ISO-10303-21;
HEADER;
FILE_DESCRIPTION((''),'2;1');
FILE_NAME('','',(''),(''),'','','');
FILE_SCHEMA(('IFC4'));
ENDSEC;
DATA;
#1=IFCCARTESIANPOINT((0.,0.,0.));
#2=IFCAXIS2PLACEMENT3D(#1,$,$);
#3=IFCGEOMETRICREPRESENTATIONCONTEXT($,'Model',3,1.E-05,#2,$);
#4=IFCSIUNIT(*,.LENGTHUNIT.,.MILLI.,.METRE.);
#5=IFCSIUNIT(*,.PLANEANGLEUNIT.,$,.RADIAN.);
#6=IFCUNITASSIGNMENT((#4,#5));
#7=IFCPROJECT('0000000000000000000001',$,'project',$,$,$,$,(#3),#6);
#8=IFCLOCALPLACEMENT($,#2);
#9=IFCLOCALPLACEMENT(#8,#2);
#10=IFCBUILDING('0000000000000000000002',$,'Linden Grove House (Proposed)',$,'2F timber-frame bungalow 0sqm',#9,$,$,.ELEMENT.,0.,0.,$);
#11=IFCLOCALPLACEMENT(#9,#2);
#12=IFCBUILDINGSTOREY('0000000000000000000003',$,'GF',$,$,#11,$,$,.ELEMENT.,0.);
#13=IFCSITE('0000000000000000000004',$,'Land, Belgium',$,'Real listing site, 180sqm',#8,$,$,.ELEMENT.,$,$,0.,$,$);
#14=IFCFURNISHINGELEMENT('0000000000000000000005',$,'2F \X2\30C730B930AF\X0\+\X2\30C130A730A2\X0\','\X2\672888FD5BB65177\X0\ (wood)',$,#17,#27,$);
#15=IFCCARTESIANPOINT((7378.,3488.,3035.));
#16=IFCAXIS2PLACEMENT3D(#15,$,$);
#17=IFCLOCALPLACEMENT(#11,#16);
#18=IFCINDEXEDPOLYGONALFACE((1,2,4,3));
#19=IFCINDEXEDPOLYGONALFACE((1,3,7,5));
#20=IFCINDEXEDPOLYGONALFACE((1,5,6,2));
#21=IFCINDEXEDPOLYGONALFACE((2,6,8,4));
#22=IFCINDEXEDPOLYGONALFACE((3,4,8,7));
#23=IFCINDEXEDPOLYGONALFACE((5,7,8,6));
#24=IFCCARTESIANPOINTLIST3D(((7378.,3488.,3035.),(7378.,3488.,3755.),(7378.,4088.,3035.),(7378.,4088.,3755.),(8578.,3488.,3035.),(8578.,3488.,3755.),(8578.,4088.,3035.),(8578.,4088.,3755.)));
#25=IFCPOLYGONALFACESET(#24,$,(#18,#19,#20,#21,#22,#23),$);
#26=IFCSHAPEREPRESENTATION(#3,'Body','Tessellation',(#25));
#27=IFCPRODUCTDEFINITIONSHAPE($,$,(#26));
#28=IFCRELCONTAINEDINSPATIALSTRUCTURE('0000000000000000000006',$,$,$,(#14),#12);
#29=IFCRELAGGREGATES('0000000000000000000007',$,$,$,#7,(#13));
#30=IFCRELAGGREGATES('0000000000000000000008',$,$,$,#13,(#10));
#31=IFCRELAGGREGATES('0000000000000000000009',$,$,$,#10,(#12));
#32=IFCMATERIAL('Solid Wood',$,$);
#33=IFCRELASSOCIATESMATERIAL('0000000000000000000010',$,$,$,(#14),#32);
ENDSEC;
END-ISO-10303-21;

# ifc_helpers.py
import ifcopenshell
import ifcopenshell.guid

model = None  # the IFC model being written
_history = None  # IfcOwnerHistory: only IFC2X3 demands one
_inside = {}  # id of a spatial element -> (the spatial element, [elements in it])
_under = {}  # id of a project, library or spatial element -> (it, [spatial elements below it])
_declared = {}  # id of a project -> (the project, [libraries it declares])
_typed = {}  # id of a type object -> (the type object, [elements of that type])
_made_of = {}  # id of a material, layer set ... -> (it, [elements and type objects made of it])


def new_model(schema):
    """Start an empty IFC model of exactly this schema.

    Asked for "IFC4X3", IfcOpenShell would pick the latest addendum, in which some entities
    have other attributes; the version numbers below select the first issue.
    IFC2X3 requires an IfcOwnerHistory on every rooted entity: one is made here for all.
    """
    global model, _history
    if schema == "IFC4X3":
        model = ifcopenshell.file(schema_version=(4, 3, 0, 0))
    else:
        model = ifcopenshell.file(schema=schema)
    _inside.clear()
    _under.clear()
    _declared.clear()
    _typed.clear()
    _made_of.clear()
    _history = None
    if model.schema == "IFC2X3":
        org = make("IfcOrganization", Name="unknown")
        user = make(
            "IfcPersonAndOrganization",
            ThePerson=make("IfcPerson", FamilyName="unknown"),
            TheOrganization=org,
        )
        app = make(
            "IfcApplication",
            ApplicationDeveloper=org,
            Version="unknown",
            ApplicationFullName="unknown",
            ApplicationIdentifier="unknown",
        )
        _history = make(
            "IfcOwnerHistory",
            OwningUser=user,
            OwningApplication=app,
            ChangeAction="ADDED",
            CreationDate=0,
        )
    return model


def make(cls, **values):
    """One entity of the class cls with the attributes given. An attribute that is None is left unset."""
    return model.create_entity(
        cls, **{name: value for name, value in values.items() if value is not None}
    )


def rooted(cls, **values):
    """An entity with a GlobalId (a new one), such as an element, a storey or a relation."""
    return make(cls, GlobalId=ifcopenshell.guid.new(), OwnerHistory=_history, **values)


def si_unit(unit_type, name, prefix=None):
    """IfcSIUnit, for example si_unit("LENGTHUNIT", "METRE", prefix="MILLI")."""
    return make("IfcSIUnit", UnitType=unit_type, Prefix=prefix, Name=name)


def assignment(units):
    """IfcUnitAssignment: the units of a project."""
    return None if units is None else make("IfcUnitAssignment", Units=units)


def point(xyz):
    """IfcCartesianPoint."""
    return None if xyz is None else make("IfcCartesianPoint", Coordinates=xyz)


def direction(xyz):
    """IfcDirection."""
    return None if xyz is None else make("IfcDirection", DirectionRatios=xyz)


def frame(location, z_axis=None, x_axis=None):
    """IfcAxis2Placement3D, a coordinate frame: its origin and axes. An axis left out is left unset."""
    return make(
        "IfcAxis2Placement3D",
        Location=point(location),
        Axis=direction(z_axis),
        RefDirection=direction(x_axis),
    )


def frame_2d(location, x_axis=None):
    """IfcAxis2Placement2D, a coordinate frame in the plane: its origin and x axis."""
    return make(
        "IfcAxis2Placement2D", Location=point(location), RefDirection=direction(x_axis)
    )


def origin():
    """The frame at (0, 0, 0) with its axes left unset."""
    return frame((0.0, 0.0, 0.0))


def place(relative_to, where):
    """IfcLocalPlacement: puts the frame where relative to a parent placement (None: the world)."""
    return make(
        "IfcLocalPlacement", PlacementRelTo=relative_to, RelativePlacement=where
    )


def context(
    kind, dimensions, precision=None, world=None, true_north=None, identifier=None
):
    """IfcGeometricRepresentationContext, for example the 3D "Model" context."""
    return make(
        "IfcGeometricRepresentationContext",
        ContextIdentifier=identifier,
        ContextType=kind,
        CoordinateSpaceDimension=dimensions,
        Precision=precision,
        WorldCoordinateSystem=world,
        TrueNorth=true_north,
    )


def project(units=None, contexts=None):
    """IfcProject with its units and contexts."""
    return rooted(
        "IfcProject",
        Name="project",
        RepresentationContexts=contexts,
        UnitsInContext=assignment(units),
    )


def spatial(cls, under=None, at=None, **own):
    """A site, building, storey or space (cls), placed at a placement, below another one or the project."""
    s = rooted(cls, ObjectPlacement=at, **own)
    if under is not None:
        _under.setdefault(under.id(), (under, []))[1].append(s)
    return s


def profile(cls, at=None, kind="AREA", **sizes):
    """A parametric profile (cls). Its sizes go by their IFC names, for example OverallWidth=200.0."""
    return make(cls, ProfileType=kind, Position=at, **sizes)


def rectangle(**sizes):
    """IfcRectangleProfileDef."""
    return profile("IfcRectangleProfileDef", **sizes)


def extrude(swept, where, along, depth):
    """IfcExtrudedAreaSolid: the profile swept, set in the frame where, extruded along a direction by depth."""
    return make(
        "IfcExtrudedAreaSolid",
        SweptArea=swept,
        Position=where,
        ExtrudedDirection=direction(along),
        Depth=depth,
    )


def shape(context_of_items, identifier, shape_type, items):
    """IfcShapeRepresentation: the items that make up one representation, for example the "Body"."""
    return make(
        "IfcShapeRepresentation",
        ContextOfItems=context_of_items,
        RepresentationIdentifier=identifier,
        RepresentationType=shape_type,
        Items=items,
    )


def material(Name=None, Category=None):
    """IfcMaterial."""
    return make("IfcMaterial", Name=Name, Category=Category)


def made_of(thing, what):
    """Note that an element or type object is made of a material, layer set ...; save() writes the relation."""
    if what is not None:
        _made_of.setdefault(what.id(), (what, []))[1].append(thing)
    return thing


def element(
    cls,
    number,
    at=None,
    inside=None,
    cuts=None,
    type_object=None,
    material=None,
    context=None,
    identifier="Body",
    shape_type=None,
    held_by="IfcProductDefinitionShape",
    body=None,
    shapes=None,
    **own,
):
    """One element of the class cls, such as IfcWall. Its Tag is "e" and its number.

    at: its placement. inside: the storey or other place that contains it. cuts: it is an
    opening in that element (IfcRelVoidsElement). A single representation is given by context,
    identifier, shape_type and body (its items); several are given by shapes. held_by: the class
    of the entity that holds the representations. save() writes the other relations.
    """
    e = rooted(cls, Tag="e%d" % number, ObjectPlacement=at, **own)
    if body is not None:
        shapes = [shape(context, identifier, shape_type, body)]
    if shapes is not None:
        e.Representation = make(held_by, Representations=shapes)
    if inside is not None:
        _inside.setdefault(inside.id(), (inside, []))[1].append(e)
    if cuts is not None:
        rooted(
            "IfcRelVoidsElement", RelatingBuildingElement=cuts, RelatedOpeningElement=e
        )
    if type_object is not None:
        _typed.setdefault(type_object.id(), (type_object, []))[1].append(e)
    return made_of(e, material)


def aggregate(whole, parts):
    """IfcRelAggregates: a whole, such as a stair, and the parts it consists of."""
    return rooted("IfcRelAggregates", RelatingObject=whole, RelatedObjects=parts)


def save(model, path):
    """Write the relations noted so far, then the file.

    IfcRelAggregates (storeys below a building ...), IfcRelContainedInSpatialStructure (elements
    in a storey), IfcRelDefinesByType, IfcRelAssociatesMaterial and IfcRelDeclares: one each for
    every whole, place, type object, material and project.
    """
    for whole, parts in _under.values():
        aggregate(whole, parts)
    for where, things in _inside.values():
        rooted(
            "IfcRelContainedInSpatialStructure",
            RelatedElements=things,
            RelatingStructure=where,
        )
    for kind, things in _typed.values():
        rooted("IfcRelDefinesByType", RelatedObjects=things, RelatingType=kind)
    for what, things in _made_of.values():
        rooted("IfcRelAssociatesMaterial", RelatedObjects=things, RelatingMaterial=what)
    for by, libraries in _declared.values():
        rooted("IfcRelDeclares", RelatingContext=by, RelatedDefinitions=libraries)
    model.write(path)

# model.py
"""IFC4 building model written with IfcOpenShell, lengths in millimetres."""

from ifc_helpers import new_model, si_unit, frame, frame_2d, origin, place, context, project, spatial, rectangle, extrude, material, element, save


model = new_model("IFC4")

# Units and contexts
model_context = context("Model", 3, precision=1e-05, world=origin())
ifc_project = project(units=[si_unit("LENGTHUNIT", "METRE", prefix="MILLI"), si_unit("PLANEANGLEUNIT", "RADIAN")], contexts=[model_context])

# Site, building, storey
site_placement = place(None, origin())
site = spatial("IfcSite", under=ifc_project, at=site_placement, Name="Land, Belgium", ObjectType="Real listing site, 180sqm", CompositionType="ELEMENT", RefElevation=0.0)
building_placement = place(site_placement, origin())
building = spatial("IfcBuilding", under=site, at=building_placement, Name="Linden Grove House (Proposed)", ObjectType="2F timber-frame bungalow 0sqm", CompositionType="ELEMENT", ElevationOfRefHeight=0.0, ElevationOfTerrain=0.0)
storey_placement = place(building_placement, origin())
storey = spatial("IfcBuildingStorey", under=building, at=storey_placement, Name="GF", CompositionType="ELEMENT", Elevation=0.0)

# Shared definitions
ifc_material_1 = material(Name="Solid Wood")

# Furnishing element
furnishing_1_placement = place(storey_placement, frame((7378.0, 3488.0, 3035.0)))
element("IfcFurnishingElement", 1, at=furnishing_1_placement, inside=storey, material=ifc_material_1, Name="2F デスク+チェア", Description="木製家具 (wood)", context=model_context, shape_type="SweptSolid", body=[
    extrude(rectangle(XDim=1200.0, YDim=600.0, at=frame_2d((600.0, 300.0))), frame((7378.0, 3488.0, 3035.0)), (0.0, 0.0, 1.0), 720.0),
])

save(model, "model.ifc")
